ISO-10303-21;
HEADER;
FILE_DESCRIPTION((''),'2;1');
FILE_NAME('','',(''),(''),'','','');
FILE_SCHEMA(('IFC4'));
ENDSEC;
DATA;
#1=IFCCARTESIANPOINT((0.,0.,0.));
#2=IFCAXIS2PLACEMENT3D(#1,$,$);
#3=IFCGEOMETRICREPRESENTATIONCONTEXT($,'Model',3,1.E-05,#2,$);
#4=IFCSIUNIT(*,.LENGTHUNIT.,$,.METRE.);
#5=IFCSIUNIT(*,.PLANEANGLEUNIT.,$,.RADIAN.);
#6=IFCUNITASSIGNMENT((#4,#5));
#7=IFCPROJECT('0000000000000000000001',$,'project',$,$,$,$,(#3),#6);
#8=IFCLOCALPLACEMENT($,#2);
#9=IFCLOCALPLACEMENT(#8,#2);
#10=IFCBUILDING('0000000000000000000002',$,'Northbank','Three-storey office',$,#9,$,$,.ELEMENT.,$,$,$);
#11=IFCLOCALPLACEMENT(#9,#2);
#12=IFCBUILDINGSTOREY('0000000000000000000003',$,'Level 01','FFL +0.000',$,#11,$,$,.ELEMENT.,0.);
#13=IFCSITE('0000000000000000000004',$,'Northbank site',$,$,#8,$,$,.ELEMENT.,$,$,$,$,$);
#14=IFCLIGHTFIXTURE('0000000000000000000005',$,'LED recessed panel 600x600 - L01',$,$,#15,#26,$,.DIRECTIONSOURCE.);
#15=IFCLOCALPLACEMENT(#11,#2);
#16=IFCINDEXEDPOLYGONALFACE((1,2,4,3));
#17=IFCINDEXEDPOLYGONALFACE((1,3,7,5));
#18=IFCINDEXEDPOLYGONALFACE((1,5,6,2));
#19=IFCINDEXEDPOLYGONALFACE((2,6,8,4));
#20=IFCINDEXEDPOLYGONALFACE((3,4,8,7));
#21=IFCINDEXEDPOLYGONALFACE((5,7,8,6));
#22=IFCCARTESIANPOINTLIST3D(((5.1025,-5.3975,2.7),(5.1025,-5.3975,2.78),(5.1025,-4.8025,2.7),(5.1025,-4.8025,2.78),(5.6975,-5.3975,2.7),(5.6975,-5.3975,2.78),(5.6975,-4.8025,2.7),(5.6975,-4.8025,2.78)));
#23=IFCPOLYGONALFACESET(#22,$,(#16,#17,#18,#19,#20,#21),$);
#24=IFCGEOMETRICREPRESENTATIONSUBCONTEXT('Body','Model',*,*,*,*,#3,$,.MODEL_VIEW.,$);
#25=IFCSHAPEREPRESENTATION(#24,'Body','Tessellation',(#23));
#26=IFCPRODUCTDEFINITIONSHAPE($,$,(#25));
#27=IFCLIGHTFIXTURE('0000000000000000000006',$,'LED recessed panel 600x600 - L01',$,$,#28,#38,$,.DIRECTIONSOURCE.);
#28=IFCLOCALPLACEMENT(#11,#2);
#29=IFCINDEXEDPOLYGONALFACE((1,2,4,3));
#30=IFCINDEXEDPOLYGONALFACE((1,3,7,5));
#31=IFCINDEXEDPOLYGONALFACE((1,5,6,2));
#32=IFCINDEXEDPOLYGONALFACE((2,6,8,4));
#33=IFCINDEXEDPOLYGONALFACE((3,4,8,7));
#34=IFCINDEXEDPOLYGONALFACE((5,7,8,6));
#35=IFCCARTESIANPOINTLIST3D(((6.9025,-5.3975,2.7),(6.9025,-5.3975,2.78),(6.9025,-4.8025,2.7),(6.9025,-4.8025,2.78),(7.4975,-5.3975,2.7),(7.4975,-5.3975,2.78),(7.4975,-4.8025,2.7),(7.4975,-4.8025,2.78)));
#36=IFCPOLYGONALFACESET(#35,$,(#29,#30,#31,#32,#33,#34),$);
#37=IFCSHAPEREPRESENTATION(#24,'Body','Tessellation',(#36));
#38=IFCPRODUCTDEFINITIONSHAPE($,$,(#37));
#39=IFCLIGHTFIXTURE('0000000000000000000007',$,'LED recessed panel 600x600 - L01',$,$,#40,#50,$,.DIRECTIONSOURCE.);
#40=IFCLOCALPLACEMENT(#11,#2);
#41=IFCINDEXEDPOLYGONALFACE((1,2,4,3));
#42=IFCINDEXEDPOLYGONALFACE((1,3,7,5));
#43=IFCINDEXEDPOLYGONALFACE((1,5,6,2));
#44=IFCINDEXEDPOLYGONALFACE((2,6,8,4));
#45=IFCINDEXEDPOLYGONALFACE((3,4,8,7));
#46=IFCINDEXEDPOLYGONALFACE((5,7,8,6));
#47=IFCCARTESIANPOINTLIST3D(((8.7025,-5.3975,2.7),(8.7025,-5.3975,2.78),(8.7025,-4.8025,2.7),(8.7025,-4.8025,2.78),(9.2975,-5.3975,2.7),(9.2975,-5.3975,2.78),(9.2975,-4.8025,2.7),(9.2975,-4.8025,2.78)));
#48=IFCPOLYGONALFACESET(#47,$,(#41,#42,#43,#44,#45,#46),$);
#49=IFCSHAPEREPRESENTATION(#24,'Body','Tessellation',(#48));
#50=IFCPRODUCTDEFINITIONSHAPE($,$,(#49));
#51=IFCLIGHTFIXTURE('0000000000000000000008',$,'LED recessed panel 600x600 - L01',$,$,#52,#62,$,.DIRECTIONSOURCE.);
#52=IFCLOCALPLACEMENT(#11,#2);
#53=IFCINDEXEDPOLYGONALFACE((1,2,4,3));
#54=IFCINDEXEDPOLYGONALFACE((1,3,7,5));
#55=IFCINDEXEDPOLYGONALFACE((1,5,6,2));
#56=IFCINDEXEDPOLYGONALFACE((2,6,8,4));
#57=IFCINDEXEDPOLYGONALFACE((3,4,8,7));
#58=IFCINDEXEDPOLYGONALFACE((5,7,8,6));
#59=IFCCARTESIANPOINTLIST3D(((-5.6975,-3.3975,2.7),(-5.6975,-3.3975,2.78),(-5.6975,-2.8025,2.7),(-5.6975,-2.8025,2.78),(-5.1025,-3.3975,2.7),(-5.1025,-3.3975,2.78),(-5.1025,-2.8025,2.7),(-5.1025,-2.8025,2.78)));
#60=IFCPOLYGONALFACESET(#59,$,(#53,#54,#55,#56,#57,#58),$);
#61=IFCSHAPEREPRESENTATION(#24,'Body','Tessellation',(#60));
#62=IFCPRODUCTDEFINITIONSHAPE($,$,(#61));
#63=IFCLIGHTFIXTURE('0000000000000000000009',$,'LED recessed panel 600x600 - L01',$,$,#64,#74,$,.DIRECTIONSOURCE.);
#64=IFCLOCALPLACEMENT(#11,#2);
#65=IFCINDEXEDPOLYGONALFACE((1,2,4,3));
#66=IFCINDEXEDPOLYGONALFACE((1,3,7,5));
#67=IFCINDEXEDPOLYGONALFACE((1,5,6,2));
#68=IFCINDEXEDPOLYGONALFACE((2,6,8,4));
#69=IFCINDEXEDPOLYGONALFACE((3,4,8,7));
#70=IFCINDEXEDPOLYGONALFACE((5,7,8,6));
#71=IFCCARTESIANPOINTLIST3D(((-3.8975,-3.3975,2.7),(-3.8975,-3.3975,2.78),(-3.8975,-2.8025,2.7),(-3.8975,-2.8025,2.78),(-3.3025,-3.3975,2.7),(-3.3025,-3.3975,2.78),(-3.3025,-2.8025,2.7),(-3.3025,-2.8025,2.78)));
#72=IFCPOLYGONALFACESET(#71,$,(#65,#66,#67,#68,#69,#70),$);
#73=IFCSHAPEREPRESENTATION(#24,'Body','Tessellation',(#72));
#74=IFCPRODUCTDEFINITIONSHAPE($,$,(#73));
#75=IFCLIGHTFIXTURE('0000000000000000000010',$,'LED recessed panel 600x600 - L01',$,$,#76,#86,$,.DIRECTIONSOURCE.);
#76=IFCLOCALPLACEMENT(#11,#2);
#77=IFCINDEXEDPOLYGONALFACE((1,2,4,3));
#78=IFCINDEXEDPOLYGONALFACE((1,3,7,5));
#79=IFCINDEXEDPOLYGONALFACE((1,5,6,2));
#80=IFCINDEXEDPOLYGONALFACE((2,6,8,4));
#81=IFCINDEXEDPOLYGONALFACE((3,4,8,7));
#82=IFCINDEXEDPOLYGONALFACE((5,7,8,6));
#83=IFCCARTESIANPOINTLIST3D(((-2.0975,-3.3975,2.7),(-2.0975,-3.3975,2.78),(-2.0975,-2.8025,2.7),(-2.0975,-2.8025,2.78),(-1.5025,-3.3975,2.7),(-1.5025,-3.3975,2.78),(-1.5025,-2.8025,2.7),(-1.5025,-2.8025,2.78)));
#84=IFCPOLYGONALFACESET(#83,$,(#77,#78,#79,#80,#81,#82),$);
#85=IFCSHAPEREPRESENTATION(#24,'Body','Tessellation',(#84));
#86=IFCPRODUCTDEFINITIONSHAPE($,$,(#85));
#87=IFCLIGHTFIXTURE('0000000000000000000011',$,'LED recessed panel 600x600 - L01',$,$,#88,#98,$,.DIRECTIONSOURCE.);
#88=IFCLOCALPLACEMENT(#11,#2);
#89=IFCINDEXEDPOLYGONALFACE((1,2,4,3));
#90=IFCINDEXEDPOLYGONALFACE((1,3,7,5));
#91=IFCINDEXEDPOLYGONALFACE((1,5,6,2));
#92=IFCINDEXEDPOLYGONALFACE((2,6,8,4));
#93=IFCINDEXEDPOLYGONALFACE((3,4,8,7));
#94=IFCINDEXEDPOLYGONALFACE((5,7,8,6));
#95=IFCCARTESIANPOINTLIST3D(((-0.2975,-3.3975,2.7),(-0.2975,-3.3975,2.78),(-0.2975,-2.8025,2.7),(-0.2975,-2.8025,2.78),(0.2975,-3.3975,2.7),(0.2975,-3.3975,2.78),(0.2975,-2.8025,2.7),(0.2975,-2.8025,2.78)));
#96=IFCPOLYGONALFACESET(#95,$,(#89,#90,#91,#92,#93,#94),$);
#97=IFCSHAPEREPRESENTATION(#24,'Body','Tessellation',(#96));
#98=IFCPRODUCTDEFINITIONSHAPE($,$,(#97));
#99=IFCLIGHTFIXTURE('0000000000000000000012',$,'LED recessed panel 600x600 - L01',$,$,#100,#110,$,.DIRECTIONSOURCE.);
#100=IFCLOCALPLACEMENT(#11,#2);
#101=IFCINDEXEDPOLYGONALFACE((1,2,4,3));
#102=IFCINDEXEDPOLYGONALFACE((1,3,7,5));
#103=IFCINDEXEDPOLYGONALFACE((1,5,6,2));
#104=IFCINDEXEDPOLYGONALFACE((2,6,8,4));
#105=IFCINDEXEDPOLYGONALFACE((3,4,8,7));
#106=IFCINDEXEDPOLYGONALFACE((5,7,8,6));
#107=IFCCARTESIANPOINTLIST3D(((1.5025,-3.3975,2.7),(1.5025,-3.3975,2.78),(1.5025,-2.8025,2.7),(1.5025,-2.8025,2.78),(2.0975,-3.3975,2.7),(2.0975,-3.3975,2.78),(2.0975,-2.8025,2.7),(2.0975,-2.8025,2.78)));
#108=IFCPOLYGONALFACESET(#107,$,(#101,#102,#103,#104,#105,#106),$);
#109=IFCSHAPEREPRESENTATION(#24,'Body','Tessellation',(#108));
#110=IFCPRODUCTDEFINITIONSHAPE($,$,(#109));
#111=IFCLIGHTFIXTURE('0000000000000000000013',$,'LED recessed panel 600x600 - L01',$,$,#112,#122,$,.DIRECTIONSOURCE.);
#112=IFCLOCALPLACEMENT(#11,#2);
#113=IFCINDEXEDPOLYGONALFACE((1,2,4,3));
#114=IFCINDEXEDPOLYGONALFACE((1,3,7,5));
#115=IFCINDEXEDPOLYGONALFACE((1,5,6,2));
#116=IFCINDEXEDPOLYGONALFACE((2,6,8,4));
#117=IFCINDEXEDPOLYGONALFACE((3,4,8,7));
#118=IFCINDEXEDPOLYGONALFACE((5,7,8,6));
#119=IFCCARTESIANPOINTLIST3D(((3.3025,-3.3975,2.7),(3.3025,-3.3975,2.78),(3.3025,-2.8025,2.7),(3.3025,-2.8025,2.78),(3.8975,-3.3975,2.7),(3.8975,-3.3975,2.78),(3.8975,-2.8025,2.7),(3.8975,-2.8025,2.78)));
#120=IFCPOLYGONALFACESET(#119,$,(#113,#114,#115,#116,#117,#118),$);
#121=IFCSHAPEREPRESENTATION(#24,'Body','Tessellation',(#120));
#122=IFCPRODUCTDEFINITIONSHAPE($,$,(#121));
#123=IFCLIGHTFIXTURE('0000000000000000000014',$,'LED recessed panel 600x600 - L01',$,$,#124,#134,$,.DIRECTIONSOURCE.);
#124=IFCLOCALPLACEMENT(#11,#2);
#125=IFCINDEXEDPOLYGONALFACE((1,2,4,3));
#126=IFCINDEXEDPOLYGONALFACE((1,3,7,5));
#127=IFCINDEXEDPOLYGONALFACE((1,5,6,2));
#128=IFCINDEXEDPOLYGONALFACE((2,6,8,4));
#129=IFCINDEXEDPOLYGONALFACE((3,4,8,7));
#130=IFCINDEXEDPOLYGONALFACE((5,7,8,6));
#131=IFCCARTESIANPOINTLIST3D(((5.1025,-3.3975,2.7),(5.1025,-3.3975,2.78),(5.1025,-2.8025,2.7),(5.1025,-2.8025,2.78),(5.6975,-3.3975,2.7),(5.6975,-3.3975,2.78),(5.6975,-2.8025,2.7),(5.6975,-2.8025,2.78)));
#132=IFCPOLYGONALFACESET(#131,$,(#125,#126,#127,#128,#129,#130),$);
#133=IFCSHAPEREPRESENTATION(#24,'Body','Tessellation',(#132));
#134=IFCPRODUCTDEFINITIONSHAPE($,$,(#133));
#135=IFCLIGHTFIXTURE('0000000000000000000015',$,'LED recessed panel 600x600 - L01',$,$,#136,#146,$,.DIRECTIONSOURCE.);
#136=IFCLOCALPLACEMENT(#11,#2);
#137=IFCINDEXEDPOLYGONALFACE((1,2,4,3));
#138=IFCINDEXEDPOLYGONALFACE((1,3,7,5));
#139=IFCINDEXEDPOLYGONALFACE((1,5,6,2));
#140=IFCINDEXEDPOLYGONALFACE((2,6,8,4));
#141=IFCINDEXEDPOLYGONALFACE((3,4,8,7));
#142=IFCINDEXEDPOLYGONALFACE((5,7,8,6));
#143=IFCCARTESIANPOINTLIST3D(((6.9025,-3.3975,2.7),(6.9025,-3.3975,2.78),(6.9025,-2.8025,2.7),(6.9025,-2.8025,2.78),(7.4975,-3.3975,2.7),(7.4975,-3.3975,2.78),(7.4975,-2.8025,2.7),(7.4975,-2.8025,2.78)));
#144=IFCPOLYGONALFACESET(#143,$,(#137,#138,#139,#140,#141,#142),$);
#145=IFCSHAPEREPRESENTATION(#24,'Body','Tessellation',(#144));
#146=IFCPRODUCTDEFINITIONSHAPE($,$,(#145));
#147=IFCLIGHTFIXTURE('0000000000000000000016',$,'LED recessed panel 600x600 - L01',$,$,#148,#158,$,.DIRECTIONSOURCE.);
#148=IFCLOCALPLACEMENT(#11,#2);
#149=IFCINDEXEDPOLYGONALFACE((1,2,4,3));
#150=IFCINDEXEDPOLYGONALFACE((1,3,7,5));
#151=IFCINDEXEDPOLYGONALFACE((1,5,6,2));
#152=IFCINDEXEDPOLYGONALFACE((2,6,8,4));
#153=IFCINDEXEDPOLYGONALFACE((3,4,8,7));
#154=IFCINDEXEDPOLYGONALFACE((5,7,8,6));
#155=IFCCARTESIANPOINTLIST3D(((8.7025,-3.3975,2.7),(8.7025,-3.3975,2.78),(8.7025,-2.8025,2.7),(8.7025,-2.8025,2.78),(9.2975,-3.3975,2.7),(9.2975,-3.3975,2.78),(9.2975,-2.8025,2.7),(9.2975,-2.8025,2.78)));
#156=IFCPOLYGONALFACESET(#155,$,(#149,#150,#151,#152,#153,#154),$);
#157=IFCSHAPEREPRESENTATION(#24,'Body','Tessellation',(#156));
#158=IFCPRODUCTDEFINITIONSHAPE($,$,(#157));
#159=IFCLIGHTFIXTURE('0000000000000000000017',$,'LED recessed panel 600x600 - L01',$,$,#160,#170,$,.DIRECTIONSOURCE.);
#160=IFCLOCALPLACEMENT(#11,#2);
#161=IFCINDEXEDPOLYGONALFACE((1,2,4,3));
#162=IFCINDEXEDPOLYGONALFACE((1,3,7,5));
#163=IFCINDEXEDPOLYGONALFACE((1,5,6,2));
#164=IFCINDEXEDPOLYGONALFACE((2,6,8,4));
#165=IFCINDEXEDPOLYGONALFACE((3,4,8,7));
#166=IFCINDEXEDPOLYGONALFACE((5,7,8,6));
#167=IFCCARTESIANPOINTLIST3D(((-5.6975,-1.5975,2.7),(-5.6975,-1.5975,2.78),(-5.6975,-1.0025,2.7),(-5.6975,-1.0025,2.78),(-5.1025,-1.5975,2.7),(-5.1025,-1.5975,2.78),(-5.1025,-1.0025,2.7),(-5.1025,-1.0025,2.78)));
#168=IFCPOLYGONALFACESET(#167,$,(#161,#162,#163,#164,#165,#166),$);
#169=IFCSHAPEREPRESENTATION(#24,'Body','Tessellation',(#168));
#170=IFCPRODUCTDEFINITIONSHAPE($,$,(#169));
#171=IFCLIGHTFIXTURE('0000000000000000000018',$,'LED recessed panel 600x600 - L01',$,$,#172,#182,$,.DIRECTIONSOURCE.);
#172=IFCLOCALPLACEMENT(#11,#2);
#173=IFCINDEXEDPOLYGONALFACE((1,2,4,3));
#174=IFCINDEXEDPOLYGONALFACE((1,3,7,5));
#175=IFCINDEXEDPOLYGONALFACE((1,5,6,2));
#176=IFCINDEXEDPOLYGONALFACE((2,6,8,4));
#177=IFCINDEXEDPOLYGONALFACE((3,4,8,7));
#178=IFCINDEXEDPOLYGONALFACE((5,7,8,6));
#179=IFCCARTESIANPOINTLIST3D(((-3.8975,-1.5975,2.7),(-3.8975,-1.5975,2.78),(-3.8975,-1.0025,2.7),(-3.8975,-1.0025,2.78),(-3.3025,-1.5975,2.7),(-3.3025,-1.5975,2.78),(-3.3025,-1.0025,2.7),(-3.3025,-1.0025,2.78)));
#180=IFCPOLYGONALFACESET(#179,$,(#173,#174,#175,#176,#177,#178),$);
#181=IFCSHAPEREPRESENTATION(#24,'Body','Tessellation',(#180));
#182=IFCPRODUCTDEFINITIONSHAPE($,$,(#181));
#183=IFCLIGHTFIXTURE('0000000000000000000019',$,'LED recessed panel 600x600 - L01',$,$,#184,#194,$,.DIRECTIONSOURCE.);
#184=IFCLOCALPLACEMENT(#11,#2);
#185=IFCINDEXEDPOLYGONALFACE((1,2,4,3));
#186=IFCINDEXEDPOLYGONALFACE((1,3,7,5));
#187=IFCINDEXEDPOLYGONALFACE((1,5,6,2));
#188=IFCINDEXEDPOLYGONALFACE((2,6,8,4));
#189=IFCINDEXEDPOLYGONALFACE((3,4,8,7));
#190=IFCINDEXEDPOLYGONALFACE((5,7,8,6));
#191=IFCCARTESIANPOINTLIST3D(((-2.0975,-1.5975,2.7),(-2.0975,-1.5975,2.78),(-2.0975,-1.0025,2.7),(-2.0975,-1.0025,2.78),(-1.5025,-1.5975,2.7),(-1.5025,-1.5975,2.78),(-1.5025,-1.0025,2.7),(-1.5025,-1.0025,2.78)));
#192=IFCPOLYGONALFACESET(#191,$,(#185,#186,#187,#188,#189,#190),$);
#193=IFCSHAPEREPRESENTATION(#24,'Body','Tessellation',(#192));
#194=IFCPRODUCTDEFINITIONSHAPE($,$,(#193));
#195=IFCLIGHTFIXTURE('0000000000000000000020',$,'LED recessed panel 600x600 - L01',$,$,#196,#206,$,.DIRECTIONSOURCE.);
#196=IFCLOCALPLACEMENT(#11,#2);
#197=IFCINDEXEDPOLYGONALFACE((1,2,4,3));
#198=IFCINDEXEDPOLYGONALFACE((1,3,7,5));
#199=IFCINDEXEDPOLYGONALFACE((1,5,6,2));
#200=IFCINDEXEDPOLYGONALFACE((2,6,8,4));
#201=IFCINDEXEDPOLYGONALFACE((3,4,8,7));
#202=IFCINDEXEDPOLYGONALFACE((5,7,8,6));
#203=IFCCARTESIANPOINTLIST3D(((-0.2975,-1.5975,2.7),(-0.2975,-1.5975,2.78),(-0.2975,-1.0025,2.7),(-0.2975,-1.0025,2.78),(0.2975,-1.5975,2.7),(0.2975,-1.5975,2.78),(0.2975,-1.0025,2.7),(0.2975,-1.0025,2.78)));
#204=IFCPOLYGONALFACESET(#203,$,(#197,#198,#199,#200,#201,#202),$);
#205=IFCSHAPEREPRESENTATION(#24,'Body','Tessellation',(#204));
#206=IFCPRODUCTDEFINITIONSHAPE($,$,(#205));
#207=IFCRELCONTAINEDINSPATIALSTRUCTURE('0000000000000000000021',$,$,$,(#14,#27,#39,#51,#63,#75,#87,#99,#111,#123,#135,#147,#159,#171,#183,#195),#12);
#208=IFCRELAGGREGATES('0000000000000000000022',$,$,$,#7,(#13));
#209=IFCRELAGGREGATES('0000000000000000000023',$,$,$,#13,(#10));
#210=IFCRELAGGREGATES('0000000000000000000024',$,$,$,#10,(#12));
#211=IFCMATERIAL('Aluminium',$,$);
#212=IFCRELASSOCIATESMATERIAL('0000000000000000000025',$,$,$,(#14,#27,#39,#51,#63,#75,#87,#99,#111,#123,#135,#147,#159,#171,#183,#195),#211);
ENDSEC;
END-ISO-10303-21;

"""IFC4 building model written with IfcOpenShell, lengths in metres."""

from ifc_helpers import new_model, si_unit, frame, origin, place, context, subcontext, project, spatial, rectangle, extrude, material, element, save


model = new_model("IFC4")

# Units and contexts
model_context = context("Model", 3, precision=1e-05, world=origin())
body_context = subcontext(model_context, "Body", "Model", "MODEL_VIEW")
ifc_project = project(units=[si_unit("LENGTHUNIT", "METRE"), si_unit("PLANEANGLEUNIT", "RADIAN")], contexts=[model_context])

# Site, building, storey
site_placement = place(None, origin())
site = spatial("IfcSite", under=ifc_project, at=site_placement, Name="Northbank site", CompositionType="ELEMENT")
building_placement = place(site_placement, origin())
building = spatial("IfcBuilding", under=site, at=building_placement, Name="Northbank", Description="Three-storey office", CompositionType="ELEMENT")
storey_placement = place(building_placement, origin())
storey = spatial("IfcBuildingStorey", under=building, at=storey_placement, Name="Level 01", Description="FFL +0.000", CompositionType="ELEMENT", Elevation=0.0)

# Light fixtures
ifc_material = material(Name="Aluminium")
light_fixture_1_placement = place(storey_placement, origin())
element("IfcLightFixture", 1, at=light_fixture_1_placement, inside=storey, material=ifc_material, Name="LED recessed panel 600x600 - L01", PredefinedType="DIRECTIONSOURCE", context=body_context, shape_type="SweptSolid", body=[
    extrude(rectangle(XDim=0.595, YDim=0.595), frame((5.4, -5.1, 2.7)), (0.0, 0.0, 1.0), 0.08),
])
light_fixture_2_placement = place(storey_placement, origin())
element("IfcLightFixture", 2, at=light_fixture_2_placement, inside=storey, material=ifc_material, Name="LED recessed panel 600x600 - L01", PredefinedType="DIRECTIONSOURCE", context=body_context, shape_type="SweptSolid", body=[
    extrude(rectangle(XDim=0.595, YDim=0.595), frame((7.2, -5.1, 2.7)), (0.0, 0.0, 1.0), 0.08),
])
light_fixture_3_placement = place(storey_placement, origin())
element("IfcLightFixture", 3, at=light_fixture_3_placement, inside=storey, material=ifc_material, Name="LED recessed panel 600x600 - L01", PredefinedType="DIRECTIONSOURCE", context=body_context, shape_type="SweptSolid", body=[
    extrude(rectangle(XDim=0.595, YDim=0.595), frame((9.0, -5.1, 2.7)), (0.0, 0.0, 1.0), 0.08),
])
light_fixture_4_placement = place(storey_placement, origin())
element("IfcLightFixture", 4, at=light_fixture_4_placement, inside=storey, material=ifc_material, Name="LED recessed panel 600x600 - L01", PredefinedType="DIRECTIONSOURCE", context=body_context, shape_type="SweptSolid", body=[
    extrude(rectangle(XDim=0.595, YDim=0.595), frame((-5.4, -3.1, 2.7)), (0.0, 0.0, 1.0), 0.08),
])
light_fixture_5_placement = place(storey_placement, origin())
element("IfcLightFixture", 5, at=light_fixture_5_placement, inside=storey, material=ifc_material, Name="LED recessed panel 600x600 - L01", PredefinedType="DIRECTIONSOURCE", context=body_context, shape_type="SweptSolid", body=[
    extrude(rectangle(XDim=0.595, YDim=0.595), frame((-3.6, -3.1, 2.7)), (0.0, 0.0, 1.0), 0.08),
])
light_fixture_6_placement = place(storey_placement, origin())
element("IfcLightFixture", 6, at=light_fixture_6_placement, inside=storey, material=ifc_material, Name="LED recessed panel 600x600 - L01", PredefinedType="DIRECTIONSOURCE", context=body_context, shape_type="SweptSolid", body=[
    extrude(rectangle(XDim=0.595, YDim=0.595), frame((-1.8, -3.1, 2.7)), (0.0, 0.0, 1.0), 0.08),
])
light_fixture_7_placement = place(storey_placement, origin())
element("IfcLightFixture", 7, at=light_fixture_7_placement, inside=storey, material=ifc_material, Name="LED recessed panel 600x600 - L01", PredefinedType="DIRECTIONSOURCE", context=body_context, shape_type="SweptSolid", body=[
    extrude(rectangle(XDim=0.595, YDim=0.595), frame((0.0, -3.1, 2.7)), (0.0, 0.0, 1.0), 0.08),
])
light_fixture_8_placement = place(storey_placement, origin())
element("IfcLightFixture", 8, at=light_fixture_8_placement, inside=storey, material=ifc_material, Name="LED recessed panel 600x600 - L01", PredefinedType="DIRECTIONSOURCE", context=body_context, shape_type="SweptSolid", body=[
    extrude(rectangle(XDim=0.595, YDim=0.595), frame((1.8, -3.1, 2.7)), (0.0, 0.0, 1.0), 0.08),
])
light_fixture_9_placement = place(storey_placement, origin())
element("IfcLightFixture", 9, at=light_fixture_9_placement, inside=storey, material=ifc_material, Name="LED recessed panel 600x600 - L01", PredefinedType="DIRECTIONSOURCE", context=body_context, shape_type="SweptSolid", body=[
    extrude(rectangle(XDim=0.595, YDim=0.595), frame((3.6, -3.1, 2.7)), (0.0, 0.0, 1.0), 0.08),
])
light_fixture_10_placement = place(storey_placement, origin())
element("IfcLightFixture", 10, at=light_fixture_10_placement, inside=storey, material=ifc_material, Name="LED recessed panel 600x600 - L01", PredefinedType="DIRECTIONSOURCE", context=body_context, shape_type="SweptSolid", body=[
    extrude(rectangle(XDim=0.595, YDim=0.595), frame((5.4, -3.1, 2.7)), (0.0, 0.0, 1.0), 0.08),
])
light_fixture_11_placement = place(storey_placement, origin())
element("IfcLightFixture", 11, at=light_fixture_11_placement, inside=storey, material=ifc_material, Name="LED recessed panel 600x600 - L01", PredefinedType="DIRECTIONSOURCE", context=body_context, shape_type="SweptSolid", body=[
    extrude(rectangle(XDim=0.595, YDim=0.595), frame((7.2, -3.1, 2.7)), (0.0, 0.0, 1.0), 0.08),
])
light_fixture_12_placement = place(storey_placement, origin())
element("IfcLightFixture", 12, at=light_fixture_12_placement, inside=storey, material=ifc_material, Name="LED recessed panel 600x600 - L01", PredefinedType="DIRECTIONSOURCE", context=body_context, shape_type="SweptSolid", body=[
    extrude(rectangle(XDim=0.595, YDim=0.595), frame((9.0, -3.1, 2.7)), (0.0, 0.0, 1.0), 0.08),
])
light_fixture_13_placement = place(storey_placement, origin())
element("IfcLightFixture", 13, at=light_fixture_13_placement, inside=storey, material=ifc_material, Name="LED recessed panel 600x600 - L01", PredefinedType="DIRECTIONSOURCE", context=body_context, shape_type="SweptSolid", body=[
    extrude(rectangle(XDim=0.595, YDim=0.595), frame((-5.4, -1.3, 2.7)), (0.0, 0.0, 1.0), 0.08),
])
light_fixture_14_placement = place(storey_placement, origin())
element("IfcLightFixture", 14, at=light_fixture_14_placement, inside=storey, material=ifc_material, Name="LED recessed panel 600x600 - L01", PredefinedType="DIRECTIONSOURCE", context=body_context, shape_type="SweptSolid", body=[
    extrude(rectangle(XDim=0.595, YDim=0.595), frame((-3.6, -1.3, 2.7)), (0.0, 0.0, 1.0), 0.08),
])
light_fixture_15_placement = place(storey_placement, origin())
element("IfcLightFixture", 15, at=light_fixture_15_placement, inside=storey, material=ifc_material, Name="LED recessed panel 600x600 - L01", PredefinedType="DIRECTIONSOURCE", context=body_context, shape_type="SweptSolid", body=[
    extrude(rectangle(XDim=0.595, YDim=0.595), frame((-1.8, -1.3, 2.7)), (0.0, 0.0, 1.0), 0.08),
])
light_fixture_16_placement = place(storey_placement, origin())
element("IfcLightFixture", 16, at=light_fixture_16_placement, inside=storey, material=ifc_material, Name="LED recessed panel 600x600 - L01", PredefinedType="DIRECTIONSOURCE", context=body_context, shape_type="SweptSolid", body=[
    extrude(rectangle(XDim=0.595, YDim=0.595), frame((0.0, -1.3, 2.7)), (0.0, 0.0, 1.0), 0.08),
])

save(model, "model.ifc")
